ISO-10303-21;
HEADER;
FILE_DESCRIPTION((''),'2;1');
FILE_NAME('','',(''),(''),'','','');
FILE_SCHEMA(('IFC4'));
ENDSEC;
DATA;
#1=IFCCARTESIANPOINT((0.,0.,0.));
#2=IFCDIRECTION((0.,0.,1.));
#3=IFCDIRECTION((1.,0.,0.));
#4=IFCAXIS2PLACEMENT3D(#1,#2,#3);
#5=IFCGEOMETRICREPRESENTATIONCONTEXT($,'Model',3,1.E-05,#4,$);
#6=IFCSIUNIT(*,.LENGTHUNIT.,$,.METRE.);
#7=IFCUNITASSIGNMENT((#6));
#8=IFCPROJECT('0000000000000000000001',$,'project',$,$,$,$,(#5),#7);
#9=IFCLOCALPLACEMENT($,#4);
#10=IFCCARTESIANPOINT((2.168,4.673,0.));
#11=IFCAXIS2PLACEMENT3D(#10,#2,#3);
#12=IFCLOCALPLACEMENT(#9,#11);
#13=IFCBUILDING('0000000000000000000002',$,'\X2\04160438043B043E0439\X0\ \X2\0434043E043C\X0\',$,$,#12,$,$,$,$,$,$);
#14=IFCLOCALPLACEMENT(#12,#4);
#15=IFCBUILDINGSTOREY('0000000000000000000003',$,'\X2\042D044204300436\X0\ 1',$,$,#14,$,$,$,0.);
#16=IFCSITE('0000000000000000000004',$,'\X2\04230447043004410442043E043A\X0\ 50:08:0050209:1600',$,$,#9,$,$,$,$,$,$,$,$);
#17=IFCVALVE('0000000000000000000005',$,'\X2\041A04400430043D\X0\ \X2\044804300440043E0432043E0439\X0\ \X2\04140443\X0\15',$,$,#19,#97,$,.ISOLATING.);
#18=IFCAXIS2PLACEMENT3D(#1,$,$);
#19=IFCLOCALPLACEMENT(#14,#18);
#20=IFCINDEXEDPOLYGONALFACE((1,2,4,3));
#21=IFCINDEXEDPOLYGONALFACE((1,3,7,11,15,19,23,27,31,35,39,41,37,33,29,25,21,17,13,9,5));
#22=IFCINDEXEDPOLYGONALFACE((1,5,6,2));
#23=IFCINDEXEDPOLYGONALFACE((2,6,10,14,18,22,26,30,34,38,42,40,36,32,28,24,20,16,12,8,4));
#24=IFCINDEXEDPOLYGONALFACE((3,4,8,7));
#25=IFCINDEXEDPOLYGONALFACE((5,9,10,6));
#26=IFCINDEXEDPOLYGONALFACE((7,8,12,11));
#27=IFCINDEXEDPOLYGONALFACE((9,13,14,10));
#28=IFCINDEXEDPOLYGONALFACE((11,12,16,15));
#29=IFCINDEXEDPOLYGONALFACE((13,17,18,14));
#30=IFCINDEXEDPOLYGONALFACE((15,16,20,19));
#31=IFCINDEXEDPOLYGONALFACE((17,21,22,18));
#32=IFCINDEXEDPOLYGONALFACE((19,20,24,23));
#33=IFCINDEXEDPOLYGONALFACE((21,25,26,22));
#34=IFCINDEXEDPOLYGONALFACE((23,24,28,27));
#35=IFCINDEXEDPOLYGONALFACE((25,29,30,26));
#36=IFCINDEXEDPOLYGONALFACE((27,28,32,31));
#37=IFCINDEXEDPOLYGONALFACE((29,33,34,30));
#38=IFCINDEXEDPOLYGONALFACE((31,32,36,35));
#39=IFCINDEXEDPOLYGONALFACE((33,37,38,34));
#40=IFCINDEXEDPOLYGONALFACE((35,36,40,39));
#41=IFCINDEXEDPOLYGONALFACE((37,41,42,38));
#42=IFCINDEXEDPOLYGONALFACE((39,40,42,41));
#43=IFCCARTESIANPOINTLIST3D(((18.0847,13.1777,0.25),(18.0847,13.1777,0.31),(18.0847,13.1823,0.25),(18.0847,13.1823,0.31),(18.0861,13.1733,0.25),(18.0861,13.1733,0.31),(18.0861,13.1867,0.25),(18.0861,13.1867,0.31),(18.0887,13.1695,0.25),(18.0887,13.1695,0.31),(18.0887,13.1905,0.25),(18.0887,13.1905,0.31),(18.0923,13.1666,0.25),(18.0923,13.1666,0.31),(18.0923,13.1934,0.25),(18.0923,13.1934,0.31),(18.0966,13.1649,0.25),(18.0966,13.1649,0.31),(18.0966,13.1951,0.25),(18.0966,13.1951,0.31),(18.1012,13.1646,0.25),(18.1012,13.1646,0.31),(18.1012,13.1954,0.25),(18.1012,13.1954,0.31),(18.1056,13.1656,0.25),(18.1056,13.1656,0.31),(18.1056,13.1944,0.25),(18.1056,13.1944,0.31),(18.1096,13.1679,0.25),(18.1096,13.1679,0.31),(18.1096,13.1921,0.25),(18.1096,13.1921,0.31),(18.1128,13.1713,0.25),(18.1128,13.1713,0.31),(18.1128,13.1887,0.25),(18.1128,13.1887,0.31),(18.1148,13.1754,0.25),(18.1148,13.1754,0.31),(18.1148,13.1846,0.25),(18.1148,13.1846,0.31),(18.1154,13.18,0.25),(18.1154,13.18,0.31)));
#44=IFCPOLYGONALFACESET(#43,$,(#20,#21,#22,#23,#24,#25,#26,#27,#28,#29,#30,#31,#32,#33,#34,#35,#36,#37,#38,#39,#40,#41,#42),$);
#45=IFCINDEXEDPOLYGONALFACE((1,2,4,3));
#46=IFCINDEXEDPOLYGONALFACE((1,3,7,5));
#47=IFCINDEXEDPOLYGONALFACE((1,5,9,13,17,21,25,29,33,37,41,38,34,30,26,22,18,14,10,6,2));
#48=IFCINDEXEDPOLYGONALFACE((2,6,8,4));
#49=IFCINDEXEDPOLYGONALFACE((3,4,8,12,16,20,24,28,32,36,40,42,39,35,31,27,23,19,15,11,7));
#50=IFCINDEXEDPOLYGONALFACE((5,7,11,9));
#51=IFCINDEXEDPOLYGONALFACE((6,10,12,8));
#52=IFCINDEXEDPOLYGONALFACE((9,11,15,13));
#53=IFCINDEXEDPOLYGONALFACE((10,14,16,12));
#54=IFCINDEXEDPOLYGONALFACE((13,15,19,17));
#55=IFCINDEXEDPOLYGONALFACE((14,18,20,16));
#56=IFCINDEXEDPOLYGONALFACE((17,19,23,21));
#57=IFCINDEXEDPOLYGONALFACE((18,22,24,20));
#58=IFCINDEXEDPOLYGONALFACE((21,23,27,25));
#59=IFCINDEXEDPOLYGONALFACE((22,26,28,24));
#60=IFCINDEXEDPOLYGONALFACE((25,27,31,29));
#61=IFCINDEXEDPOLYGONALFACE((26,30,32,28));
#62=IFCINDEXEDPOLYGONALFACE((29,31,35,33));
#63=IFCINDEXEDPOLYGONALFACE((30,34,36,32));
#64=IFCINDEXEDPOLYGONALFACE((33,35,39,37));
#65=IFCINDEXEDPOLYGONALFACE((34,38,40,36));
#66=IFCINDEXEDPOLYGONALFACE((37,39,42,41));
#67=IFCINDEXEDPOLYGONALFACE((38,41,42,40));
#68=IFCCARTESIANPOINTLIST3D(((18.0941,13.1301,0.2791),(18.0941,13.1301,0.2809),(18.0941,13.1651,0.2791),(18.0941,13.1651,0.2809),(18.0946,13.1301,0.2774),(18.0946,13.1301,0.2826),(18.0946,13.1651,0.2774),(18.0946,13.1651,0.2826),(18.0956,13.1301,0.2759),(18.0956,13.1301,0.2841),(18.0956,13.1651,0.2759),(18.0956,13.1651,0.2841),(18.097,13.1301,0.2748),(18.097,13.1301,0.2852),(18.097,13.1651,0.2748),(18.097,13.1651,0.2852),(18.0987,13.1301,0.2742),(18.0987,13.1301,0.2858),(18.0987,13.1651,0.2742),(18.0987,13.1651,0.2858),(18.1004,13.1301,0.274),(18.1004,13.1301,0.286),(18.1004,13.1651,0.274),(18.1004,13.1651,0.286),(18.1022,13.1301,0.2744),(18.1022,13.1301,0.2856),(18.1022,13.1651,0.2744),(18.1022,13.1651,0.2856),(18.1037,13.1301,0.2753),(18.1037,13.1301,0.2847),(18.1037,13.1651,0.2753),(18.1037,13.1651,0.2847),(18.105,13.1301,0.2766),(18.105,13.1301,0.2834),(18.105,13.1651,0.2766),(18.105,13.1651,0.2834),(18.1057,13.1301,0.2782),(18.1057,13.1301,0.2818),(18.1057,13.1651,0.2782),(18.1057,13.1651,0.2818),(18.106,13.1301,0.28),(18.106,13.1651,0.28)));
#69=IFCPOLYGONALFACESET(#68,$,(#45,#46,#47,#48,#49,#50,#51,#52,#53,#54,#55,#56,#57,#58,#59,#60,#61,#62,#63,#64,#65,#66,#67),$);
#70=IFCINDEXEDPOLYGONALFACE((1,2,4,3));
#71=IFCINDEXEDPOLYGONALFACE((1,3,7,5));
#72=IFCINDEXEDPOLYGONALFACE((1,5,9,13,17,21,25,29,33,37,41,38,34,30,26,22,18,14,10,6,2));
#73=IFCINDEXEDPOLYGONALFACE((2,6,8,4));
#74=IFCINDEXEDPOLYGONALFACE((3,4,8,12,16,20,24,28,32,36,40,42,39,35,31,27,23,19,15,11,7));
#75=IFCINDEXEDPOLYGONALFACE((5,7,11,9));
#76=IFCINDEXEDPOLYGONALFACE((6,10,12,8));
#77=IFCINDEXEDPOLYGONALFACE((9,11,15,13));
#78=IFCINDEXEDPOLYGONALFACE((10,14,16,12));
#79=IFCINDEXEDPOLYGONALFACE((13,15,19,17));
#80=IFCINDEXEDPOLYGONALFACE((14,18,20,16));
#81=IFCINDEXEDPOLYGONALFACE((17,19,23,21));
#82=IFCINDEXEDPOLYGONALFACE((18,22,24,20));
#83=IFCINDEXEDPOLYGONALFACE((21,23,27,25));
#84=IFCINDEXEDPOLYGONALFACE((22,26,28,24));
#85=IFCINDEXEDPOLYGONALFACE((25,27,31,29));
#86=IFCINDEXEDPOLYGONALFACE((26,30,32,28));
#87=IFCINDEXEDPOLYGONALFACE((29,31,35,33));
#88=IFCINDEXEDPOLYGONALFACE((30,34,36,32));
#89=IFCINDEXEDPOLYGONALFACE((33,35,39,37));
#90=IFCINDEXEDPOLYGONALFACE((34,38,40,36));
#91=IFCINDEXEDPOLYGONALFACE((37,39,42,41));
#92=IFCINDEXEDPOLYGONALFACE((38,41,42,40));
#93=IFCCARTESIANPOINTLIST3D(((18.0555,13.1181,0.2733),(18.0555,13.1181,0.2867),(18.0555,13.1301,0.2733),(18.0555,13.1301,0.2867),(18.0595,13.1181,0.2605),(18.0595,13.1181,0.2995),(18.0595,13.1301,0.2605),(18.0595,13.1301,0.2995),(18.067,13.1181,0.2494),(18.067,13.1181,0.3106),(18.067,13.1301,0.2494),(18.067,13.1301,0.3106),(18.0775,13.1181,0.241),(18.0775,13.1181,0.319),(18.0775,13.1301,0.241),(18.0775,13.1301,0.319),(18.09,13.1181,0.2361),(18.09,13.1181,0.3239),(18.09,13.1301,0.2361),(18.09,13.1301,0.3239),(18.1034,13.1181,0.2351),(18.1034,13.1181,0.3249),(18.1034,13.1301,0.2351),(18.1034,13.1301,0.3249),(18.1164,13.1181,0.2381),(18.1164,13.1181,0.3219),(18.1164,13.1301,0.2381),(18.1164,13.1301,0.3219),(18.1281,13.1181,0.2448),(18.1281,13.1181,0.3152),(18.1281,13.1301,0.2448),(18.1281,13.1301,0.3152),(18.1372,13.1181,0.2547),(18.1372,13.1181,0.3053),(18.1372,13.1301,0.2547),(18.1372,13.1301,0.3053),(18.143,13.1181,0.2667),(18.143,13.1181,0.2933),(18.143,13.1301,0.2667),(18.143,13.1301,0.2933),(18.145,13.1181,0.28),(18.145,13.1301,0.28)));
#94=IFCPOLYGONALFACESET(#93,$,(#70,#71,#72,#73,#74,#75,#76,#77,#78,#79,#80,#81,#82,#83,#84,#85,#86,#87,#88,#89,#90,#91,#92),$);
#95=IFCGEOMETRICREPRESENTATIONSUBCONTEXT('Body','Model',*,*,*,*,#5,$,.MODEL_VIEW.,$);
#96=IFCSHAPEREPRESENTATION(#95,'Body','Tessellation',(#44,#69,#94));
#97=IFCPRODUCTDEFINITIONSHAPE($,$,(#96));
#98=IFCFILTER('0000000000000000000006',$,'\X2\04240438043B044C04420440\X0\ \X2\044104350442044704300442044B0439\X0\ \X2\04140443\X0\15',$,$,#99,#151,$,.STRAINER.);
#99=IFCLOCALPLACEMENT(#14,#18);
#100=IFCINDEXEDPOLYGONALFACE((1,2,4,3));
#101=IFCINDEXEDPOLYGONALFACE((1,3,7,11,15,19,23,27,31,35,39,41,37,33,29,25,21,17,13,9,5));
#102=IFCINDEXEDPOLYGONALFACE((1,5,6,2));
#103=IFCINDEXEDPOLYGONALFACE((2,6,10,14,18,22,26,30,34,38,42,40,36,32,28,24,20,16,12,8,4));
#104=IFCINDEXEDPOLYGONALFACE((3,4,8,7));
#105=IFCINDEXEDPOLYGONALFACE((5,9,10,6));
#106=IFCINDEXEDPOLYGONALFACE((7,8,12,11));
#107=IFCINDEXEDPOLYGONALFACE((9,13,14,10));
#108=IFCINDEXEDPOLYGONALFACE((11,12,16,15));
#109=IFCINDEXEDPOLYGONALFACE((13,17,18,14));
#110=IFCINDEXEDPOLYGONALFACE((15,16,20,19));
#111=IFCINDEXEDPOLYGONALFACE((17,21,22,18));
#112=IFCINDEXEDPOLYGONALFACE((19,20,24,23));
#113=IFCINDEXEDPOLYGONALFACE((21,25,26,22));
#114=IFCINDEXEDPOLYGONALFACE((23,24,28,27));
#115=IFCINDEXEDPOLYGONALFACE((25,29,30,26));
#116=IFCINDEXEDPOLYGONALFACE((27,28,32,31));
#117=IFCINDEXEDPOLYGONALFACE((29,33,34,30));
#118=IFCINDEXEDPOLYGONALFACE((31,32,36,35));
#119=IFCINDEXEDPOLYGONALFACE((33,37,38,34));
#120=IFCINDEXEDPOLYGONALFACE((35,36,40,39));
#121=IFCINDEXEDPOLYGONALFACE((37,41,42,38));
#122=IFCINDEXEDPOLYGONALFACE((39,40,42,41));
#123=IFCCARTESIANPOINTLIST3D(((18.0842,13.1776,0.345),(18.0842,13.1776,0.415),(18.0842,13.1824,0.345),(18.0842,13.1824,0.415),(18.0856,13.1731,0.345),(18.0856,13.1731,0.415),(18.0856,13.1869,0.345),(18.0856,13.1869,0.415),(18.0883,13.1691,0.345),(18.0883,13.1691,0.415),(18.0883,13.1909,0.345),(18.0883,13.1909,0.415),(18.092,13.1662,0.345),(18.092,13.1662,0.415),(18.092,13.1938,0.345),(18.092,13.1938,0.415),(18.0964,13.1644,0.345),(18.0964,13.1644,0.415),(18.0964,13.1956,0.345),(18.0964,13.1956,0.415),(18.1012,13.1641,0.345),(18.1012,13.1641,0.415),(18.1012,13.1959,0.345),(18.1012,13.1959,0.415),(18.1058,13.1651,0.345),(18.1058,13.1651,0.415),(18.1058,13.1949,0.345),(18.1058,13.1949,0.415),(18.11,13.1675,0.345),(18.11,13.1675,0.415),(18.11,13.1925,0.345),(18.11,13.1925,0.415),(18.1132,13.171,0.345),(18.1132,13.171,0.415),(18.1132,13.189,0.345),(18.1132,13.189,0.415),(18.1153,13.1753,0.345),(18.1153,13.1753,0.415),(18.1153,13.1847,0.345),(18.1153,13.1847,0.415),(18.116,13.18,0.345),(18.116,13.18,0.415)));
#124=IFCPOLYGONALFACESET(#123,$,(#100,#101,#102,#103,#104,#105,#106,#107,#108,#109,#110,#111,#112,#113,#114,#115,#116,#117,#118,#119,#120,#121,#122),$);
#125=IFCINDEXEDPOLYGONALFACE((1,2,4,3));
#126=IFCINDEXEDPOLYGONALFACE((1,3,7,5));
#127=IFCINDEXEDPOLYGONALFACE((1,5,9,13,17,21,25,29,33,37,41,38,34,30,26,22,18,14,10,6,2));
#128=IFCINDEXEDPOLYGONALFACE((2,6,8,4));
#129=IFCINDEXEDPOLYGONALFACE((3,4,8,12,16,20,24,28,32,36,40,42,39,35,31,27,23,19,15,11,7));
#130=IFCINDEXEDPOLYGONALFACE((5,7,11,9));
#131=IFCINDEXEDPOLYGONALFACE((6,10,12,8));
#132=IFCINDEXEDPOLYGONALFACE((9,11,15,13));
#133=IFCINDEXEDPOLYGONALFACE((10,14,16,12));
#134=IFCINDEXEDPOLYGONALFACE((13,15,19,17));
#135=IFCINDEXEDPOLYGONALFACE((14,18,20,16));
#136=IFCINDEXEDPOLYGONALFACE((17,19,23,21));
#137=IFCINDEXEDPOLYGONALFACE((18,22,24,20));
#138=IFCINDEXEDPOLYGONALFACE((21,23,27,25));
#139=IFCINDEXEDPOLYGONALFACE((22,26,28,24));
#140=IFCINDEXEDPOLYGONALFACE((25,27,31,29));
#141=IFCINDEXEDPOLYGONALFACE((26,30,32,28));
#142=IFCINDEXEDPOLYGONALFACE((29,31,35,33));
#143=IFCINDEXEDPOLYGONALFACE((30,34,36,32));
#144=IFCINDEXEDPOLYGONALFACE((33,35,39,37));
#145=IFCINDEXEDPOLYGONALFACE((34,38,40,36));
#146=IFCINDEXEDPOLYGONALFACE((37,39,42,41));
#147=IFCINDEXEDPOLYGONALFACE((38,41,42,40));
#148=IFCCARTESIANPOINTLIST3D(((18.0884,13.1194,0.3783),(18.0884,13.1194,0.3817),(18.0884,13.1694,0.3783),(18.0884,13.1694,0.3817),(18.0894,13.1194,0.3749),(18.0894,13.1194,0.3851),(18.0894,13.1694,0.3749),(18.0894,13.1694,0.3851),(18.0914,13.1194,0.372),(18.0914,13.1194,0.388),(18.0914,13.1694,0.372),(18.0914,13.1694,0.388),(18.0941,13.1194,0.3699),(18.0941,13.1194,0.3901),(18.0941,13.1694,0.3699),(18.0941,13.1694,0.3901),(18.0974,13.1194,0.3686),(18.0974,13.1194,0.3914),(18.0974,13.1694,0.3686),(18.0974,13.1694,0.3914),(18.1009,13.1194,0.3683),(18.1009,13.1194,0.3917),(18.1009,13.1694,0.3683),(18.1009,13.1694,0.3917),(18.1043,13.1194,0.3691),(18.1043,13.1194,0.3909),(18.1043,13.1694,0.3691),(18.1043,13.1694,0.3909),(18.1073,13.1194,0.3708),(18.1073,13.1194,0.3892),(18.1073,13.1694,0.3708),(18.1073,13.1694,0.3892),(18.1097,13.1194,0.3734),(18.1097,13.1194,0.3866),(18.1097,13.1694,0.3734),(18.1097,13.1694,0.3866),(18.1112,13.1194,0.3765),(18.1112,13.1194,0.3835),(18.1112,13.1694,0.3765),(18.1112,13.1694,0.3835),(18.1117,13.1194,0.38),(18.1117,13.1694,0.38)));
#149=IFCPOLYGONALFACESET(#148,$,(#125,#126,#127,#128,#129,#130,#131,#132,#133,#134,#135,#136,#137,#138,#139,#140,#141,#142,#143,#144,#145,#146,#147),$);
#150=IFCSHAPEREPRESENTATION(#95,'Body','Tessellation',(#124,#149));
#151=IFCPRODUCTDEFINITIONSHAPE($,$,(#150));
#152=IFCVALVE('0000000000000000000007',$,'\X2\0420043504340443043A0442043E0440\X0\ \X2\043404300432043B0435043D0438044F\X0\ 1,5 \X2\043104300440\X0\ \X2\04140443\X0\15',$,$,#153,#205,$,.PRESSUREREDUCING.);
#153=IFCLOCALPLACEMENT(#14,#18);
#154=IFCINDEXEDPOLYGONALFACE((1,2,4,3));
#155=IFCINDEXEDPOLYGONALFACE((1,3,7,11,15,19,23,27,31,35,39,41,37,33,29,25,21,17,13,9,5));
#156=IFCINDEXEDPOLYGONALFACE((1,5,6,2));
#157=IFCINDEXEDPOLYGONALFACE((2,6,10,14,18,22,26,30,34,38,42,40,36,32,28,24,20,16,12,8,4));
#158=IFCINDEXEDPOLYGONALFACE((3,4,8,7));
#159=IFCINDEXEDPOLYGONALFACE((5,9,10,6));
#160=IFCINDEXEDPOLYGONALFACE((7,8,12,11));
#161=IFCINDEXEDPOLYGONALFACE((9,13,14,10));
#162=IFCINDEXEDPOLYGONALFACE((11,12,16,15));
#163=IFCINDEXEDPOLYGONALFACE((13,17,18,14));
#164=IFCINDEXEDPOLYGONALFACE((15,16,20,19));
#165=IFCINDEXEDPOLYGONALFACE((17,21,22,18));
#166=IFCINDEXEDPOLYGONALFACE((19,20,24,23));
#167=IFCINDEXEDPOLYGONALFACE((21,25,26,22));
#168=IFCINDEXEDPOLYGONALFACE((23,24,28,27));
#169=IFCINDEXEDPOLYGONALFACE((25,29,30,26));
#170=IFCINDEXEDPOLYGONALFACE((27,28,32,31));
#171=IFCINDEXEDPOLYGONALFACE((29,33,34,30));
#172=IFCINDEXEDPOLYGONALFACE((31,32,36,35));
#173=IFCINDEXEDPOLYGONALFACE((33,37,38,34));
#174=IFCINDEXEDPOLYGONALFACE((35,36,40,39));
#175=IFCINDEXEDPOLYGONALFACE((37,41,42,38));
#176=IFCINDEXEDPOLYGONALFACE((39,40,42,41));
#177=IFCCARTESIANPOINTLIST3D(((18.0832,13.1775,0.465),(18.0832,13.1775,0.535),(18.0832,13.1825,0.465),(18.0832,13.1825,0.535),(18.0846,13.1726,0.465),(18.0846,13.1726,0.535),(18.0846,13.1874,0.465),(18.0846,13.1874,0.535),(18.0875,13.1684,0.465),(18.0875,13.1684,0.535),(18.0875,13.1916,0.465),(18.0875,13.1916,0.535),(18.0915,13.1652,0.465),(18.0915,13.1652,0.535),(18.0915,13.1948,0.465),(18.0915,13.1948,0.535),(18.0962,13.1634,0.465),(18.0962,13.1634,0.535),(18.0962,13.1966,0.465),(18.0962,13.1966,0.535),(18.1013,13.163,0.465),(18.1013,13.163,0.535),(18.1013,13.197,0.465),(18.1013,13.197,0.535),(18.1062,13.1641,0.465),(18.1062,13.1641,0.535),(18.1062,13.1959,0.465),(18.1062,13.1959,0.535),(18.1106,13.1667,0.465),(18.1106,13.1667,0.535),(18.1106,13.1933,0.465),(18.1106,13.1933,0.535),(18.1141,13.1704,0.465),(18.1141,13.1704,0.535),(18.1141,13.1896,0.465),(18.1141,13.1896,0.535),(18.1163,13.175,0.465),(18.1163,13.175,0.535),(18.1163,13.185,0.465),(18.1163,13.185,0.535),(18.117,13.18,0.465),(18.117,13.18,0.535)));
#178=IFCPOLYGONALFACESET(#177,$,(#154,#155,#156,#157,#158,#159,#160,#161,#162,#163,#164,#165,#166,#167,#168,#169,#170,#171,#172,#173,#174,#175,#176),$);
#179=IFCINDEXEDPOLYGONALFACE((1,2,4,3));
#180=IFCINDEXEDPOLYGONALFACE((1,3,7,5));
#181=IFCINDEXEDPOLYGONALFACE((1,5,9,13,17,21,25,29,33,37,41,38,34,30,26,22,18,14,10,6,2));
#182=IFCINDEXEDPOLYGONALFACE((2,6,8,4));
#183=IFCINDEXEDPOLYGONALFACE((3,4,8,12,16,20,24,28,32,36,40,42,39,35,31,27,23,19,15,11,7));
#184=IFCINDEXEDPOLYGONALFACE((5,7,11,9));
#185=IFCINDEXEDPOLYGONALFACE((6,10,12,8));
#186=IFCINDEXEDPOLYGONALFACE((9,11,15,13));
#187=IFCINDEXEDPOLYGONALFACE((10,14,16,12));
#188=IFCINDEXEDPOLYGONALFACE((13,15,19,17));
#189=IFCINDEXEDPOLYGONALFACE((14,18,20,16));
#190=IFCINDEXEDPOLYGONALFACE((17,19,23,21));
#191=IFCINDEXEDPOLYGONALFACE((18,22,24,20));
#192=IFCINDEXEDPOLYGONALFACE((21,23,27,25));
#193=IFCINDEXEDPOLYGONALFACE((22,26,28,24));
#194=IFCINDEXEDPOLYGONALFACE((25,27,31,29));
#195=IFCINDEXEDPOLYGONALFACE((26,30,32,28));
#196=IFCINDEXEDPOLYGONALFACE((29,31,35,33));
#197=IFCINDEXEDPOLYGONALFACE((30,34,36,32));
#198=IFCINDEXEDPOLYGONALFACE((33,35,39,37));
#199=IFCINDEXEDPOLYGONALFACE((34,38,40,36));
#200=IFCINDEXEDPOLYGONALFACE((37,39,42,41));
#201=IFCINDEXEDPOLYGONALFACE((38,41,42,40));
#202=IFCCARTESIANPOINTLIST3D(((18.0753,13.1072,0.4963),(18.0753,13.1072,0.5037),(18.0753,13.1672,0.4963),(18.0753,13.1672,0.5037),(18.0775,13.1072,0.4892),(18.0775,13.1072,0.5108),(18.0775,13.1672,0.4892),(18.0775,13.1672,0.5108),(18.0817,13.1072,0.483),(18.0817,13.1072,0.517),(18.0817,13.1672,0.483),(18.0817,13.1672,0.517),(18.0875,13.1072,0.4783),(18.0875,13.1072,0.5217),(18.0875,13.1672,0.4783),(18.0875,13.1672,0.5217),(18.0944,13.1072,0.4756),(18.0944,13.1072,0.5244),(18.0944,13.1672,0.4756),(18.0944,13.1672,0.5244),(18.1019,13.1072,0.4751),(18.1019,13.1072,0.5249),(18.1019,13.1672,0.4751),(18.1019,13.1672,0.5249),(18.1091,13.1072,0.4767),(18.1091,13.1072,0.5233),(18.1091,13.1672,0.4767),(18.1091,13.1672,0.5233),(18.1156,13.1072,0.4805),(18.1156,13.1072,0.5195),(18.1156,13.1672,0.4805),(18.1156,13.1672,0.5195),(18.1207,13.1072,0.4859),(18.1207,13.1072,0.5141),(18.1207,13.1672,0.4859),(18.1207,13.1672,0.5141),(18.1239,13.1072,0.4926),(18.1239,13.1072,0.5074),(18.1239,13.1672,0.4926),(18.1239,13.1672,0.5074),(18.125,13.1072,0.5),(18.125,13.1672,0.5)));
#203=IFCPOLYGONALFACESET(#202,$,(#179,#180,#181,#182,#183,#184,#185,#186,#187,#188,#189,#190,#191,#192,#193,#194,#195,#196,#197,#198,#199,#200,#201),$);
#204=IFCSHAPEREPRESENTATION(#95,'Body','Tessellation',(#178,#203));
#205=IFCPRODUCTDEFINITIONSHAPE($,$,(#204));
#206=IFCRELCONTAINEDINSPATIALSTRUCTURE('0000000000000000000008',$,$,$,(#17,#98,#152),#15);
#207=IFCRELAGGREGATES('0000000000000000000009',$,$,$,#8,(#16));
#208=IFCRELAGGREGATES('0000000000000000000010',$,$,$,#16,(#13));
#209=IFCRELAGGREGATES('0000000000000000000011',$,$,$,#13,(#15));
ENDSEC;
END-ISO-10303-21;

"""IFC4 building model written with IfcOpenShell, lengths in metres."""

from ifc_helpers import new_model, si_unit, frame, origin_with_axes, origin_2d, place, context, subcontext, project, spatial, circle, extrude, element, save


model = new_model("IFC4")

# Units and contexts
model_context = context("Model", 3, precision=1e-05, world=origin_with_axes())
body_context = subcontext(model_context, "Body", "Model", "MODEL_VIEW")
ifc_project = project(units=[si_unit("LENGTHUNIT", "METRE")], contexts=[model_context])

# Site, building, storey
site_placement = place(None, origin_with_axes())
site = spatial("IfcSite", under=ifc_project, at=site_placement, Name="Участок 50:08:0050209:1600")
building_placement = place(site_placement, frame((2.168, 4.673, 0.0), z_axis=(0.0, 0.0, 1.0), x_axis=(1.0, 0.0, 0.0)))
building = spatial("IfcBuilding", under=site, at=building_placement, Name="Жилой дом")
storey_placement = place(building_placement, origin_with_axes())
storey = spatial("IfcBuildingStorey", under=building, at=storey_placement, Name="Этаж 1", Elevation=0.0)

# Valve
valve_1_placement = place(storey_placement, origin_with_axes())
element("IfcValve", 1, at=valve_1_placement, inside=storey, Name="Кран шаровой Ду15", PredefinedType="ISOLATING", context=body_context, shape_type="SweptSolid", body=[
    extrude(circle(Radius=0.0154, at=origin_2d()), frame((18.1, 13.18, 0.25), z_axis=(0.0, 0.0, 1.0), x_axis=(1.0, 0.0, 0.0)), (0.0, 0.0, 1.0), 0.06),
    extrude(circle(Radius=0.006, at=origin_2d()), frame((18.1, 13.1651, 0.28), z_axis=(0.0, -1.0, 0.0), x_axis=(1.0, 0.0, 0.0)), (0.0, 0.0, 1.0), 0.035),
    extrude(circle(Radius=0.045, at=origin_2d()), frame((18.1, 13.1301, 0.28), z_axis=(0.0, -1.0, 0.0), x_axis=(1.0, 0.0, 0.0)), (0.0, 0.0, 1.0), 0.012),
])

# Filter
ifc_filter_1_placement = place(storey_placement, origin_with_axes())
element("IfcFilter", 2, at=ifc_filter_1_placement, inside=storey, Name="Фильтр сетчатый Ду15", PredefinedType="STRAINER", context=body_context, shape_type="SweptSolid", body=[
    extrude(circle(Radius=0.016, at=origin_2d()), frame((18.1, 13.18, 0.345), z_axis=(0.0, 0.0, 1.0), x_axis=(1.0, 0.0, 0.0)), (0.0, 0.0, 1.0), 0.07),
    extrude(circle(Radius=0.0117, at=origin_2d()), frame((18.1, 13.1693, 0.38), z_axis=(0.0, -1.0, 0.0), x_axis=(1.0, 0.0, 0.0)), (0.0, 0.0, 1.0), 0.05),
])

# Valve
valve_2_placement = place(storey_placement, origin_with_axes())
element("IfcValve", 3, at=valve_2_placement, inside=storey, Name="Редуктор давления 1,5 бар Ду15", PredefinedType="PRESSUREREDUCING", context=body_context, shape_type="SweptSolid", body=[
    extrude(circle(Radius=0.017, at=origin_2d()), frame((18.1, 13.18, 0.465), z_axis=(0.0, 0.0, 1.0), x_axis=(1.0, 0.0, 0.0)), (0.0, 0.0, 1.0), 0.07),
    extrude(circle(Radius=0.025, at=origin_2d()), frame((18.1, 13.1672, 0.5), z_axis=(0.0, -1.0, 0.0), x_axis=(1.0, 0.0, 0.0)), (0.0, 0.0, 1.0), 0.06),
])

save(model, "model.ifc")
